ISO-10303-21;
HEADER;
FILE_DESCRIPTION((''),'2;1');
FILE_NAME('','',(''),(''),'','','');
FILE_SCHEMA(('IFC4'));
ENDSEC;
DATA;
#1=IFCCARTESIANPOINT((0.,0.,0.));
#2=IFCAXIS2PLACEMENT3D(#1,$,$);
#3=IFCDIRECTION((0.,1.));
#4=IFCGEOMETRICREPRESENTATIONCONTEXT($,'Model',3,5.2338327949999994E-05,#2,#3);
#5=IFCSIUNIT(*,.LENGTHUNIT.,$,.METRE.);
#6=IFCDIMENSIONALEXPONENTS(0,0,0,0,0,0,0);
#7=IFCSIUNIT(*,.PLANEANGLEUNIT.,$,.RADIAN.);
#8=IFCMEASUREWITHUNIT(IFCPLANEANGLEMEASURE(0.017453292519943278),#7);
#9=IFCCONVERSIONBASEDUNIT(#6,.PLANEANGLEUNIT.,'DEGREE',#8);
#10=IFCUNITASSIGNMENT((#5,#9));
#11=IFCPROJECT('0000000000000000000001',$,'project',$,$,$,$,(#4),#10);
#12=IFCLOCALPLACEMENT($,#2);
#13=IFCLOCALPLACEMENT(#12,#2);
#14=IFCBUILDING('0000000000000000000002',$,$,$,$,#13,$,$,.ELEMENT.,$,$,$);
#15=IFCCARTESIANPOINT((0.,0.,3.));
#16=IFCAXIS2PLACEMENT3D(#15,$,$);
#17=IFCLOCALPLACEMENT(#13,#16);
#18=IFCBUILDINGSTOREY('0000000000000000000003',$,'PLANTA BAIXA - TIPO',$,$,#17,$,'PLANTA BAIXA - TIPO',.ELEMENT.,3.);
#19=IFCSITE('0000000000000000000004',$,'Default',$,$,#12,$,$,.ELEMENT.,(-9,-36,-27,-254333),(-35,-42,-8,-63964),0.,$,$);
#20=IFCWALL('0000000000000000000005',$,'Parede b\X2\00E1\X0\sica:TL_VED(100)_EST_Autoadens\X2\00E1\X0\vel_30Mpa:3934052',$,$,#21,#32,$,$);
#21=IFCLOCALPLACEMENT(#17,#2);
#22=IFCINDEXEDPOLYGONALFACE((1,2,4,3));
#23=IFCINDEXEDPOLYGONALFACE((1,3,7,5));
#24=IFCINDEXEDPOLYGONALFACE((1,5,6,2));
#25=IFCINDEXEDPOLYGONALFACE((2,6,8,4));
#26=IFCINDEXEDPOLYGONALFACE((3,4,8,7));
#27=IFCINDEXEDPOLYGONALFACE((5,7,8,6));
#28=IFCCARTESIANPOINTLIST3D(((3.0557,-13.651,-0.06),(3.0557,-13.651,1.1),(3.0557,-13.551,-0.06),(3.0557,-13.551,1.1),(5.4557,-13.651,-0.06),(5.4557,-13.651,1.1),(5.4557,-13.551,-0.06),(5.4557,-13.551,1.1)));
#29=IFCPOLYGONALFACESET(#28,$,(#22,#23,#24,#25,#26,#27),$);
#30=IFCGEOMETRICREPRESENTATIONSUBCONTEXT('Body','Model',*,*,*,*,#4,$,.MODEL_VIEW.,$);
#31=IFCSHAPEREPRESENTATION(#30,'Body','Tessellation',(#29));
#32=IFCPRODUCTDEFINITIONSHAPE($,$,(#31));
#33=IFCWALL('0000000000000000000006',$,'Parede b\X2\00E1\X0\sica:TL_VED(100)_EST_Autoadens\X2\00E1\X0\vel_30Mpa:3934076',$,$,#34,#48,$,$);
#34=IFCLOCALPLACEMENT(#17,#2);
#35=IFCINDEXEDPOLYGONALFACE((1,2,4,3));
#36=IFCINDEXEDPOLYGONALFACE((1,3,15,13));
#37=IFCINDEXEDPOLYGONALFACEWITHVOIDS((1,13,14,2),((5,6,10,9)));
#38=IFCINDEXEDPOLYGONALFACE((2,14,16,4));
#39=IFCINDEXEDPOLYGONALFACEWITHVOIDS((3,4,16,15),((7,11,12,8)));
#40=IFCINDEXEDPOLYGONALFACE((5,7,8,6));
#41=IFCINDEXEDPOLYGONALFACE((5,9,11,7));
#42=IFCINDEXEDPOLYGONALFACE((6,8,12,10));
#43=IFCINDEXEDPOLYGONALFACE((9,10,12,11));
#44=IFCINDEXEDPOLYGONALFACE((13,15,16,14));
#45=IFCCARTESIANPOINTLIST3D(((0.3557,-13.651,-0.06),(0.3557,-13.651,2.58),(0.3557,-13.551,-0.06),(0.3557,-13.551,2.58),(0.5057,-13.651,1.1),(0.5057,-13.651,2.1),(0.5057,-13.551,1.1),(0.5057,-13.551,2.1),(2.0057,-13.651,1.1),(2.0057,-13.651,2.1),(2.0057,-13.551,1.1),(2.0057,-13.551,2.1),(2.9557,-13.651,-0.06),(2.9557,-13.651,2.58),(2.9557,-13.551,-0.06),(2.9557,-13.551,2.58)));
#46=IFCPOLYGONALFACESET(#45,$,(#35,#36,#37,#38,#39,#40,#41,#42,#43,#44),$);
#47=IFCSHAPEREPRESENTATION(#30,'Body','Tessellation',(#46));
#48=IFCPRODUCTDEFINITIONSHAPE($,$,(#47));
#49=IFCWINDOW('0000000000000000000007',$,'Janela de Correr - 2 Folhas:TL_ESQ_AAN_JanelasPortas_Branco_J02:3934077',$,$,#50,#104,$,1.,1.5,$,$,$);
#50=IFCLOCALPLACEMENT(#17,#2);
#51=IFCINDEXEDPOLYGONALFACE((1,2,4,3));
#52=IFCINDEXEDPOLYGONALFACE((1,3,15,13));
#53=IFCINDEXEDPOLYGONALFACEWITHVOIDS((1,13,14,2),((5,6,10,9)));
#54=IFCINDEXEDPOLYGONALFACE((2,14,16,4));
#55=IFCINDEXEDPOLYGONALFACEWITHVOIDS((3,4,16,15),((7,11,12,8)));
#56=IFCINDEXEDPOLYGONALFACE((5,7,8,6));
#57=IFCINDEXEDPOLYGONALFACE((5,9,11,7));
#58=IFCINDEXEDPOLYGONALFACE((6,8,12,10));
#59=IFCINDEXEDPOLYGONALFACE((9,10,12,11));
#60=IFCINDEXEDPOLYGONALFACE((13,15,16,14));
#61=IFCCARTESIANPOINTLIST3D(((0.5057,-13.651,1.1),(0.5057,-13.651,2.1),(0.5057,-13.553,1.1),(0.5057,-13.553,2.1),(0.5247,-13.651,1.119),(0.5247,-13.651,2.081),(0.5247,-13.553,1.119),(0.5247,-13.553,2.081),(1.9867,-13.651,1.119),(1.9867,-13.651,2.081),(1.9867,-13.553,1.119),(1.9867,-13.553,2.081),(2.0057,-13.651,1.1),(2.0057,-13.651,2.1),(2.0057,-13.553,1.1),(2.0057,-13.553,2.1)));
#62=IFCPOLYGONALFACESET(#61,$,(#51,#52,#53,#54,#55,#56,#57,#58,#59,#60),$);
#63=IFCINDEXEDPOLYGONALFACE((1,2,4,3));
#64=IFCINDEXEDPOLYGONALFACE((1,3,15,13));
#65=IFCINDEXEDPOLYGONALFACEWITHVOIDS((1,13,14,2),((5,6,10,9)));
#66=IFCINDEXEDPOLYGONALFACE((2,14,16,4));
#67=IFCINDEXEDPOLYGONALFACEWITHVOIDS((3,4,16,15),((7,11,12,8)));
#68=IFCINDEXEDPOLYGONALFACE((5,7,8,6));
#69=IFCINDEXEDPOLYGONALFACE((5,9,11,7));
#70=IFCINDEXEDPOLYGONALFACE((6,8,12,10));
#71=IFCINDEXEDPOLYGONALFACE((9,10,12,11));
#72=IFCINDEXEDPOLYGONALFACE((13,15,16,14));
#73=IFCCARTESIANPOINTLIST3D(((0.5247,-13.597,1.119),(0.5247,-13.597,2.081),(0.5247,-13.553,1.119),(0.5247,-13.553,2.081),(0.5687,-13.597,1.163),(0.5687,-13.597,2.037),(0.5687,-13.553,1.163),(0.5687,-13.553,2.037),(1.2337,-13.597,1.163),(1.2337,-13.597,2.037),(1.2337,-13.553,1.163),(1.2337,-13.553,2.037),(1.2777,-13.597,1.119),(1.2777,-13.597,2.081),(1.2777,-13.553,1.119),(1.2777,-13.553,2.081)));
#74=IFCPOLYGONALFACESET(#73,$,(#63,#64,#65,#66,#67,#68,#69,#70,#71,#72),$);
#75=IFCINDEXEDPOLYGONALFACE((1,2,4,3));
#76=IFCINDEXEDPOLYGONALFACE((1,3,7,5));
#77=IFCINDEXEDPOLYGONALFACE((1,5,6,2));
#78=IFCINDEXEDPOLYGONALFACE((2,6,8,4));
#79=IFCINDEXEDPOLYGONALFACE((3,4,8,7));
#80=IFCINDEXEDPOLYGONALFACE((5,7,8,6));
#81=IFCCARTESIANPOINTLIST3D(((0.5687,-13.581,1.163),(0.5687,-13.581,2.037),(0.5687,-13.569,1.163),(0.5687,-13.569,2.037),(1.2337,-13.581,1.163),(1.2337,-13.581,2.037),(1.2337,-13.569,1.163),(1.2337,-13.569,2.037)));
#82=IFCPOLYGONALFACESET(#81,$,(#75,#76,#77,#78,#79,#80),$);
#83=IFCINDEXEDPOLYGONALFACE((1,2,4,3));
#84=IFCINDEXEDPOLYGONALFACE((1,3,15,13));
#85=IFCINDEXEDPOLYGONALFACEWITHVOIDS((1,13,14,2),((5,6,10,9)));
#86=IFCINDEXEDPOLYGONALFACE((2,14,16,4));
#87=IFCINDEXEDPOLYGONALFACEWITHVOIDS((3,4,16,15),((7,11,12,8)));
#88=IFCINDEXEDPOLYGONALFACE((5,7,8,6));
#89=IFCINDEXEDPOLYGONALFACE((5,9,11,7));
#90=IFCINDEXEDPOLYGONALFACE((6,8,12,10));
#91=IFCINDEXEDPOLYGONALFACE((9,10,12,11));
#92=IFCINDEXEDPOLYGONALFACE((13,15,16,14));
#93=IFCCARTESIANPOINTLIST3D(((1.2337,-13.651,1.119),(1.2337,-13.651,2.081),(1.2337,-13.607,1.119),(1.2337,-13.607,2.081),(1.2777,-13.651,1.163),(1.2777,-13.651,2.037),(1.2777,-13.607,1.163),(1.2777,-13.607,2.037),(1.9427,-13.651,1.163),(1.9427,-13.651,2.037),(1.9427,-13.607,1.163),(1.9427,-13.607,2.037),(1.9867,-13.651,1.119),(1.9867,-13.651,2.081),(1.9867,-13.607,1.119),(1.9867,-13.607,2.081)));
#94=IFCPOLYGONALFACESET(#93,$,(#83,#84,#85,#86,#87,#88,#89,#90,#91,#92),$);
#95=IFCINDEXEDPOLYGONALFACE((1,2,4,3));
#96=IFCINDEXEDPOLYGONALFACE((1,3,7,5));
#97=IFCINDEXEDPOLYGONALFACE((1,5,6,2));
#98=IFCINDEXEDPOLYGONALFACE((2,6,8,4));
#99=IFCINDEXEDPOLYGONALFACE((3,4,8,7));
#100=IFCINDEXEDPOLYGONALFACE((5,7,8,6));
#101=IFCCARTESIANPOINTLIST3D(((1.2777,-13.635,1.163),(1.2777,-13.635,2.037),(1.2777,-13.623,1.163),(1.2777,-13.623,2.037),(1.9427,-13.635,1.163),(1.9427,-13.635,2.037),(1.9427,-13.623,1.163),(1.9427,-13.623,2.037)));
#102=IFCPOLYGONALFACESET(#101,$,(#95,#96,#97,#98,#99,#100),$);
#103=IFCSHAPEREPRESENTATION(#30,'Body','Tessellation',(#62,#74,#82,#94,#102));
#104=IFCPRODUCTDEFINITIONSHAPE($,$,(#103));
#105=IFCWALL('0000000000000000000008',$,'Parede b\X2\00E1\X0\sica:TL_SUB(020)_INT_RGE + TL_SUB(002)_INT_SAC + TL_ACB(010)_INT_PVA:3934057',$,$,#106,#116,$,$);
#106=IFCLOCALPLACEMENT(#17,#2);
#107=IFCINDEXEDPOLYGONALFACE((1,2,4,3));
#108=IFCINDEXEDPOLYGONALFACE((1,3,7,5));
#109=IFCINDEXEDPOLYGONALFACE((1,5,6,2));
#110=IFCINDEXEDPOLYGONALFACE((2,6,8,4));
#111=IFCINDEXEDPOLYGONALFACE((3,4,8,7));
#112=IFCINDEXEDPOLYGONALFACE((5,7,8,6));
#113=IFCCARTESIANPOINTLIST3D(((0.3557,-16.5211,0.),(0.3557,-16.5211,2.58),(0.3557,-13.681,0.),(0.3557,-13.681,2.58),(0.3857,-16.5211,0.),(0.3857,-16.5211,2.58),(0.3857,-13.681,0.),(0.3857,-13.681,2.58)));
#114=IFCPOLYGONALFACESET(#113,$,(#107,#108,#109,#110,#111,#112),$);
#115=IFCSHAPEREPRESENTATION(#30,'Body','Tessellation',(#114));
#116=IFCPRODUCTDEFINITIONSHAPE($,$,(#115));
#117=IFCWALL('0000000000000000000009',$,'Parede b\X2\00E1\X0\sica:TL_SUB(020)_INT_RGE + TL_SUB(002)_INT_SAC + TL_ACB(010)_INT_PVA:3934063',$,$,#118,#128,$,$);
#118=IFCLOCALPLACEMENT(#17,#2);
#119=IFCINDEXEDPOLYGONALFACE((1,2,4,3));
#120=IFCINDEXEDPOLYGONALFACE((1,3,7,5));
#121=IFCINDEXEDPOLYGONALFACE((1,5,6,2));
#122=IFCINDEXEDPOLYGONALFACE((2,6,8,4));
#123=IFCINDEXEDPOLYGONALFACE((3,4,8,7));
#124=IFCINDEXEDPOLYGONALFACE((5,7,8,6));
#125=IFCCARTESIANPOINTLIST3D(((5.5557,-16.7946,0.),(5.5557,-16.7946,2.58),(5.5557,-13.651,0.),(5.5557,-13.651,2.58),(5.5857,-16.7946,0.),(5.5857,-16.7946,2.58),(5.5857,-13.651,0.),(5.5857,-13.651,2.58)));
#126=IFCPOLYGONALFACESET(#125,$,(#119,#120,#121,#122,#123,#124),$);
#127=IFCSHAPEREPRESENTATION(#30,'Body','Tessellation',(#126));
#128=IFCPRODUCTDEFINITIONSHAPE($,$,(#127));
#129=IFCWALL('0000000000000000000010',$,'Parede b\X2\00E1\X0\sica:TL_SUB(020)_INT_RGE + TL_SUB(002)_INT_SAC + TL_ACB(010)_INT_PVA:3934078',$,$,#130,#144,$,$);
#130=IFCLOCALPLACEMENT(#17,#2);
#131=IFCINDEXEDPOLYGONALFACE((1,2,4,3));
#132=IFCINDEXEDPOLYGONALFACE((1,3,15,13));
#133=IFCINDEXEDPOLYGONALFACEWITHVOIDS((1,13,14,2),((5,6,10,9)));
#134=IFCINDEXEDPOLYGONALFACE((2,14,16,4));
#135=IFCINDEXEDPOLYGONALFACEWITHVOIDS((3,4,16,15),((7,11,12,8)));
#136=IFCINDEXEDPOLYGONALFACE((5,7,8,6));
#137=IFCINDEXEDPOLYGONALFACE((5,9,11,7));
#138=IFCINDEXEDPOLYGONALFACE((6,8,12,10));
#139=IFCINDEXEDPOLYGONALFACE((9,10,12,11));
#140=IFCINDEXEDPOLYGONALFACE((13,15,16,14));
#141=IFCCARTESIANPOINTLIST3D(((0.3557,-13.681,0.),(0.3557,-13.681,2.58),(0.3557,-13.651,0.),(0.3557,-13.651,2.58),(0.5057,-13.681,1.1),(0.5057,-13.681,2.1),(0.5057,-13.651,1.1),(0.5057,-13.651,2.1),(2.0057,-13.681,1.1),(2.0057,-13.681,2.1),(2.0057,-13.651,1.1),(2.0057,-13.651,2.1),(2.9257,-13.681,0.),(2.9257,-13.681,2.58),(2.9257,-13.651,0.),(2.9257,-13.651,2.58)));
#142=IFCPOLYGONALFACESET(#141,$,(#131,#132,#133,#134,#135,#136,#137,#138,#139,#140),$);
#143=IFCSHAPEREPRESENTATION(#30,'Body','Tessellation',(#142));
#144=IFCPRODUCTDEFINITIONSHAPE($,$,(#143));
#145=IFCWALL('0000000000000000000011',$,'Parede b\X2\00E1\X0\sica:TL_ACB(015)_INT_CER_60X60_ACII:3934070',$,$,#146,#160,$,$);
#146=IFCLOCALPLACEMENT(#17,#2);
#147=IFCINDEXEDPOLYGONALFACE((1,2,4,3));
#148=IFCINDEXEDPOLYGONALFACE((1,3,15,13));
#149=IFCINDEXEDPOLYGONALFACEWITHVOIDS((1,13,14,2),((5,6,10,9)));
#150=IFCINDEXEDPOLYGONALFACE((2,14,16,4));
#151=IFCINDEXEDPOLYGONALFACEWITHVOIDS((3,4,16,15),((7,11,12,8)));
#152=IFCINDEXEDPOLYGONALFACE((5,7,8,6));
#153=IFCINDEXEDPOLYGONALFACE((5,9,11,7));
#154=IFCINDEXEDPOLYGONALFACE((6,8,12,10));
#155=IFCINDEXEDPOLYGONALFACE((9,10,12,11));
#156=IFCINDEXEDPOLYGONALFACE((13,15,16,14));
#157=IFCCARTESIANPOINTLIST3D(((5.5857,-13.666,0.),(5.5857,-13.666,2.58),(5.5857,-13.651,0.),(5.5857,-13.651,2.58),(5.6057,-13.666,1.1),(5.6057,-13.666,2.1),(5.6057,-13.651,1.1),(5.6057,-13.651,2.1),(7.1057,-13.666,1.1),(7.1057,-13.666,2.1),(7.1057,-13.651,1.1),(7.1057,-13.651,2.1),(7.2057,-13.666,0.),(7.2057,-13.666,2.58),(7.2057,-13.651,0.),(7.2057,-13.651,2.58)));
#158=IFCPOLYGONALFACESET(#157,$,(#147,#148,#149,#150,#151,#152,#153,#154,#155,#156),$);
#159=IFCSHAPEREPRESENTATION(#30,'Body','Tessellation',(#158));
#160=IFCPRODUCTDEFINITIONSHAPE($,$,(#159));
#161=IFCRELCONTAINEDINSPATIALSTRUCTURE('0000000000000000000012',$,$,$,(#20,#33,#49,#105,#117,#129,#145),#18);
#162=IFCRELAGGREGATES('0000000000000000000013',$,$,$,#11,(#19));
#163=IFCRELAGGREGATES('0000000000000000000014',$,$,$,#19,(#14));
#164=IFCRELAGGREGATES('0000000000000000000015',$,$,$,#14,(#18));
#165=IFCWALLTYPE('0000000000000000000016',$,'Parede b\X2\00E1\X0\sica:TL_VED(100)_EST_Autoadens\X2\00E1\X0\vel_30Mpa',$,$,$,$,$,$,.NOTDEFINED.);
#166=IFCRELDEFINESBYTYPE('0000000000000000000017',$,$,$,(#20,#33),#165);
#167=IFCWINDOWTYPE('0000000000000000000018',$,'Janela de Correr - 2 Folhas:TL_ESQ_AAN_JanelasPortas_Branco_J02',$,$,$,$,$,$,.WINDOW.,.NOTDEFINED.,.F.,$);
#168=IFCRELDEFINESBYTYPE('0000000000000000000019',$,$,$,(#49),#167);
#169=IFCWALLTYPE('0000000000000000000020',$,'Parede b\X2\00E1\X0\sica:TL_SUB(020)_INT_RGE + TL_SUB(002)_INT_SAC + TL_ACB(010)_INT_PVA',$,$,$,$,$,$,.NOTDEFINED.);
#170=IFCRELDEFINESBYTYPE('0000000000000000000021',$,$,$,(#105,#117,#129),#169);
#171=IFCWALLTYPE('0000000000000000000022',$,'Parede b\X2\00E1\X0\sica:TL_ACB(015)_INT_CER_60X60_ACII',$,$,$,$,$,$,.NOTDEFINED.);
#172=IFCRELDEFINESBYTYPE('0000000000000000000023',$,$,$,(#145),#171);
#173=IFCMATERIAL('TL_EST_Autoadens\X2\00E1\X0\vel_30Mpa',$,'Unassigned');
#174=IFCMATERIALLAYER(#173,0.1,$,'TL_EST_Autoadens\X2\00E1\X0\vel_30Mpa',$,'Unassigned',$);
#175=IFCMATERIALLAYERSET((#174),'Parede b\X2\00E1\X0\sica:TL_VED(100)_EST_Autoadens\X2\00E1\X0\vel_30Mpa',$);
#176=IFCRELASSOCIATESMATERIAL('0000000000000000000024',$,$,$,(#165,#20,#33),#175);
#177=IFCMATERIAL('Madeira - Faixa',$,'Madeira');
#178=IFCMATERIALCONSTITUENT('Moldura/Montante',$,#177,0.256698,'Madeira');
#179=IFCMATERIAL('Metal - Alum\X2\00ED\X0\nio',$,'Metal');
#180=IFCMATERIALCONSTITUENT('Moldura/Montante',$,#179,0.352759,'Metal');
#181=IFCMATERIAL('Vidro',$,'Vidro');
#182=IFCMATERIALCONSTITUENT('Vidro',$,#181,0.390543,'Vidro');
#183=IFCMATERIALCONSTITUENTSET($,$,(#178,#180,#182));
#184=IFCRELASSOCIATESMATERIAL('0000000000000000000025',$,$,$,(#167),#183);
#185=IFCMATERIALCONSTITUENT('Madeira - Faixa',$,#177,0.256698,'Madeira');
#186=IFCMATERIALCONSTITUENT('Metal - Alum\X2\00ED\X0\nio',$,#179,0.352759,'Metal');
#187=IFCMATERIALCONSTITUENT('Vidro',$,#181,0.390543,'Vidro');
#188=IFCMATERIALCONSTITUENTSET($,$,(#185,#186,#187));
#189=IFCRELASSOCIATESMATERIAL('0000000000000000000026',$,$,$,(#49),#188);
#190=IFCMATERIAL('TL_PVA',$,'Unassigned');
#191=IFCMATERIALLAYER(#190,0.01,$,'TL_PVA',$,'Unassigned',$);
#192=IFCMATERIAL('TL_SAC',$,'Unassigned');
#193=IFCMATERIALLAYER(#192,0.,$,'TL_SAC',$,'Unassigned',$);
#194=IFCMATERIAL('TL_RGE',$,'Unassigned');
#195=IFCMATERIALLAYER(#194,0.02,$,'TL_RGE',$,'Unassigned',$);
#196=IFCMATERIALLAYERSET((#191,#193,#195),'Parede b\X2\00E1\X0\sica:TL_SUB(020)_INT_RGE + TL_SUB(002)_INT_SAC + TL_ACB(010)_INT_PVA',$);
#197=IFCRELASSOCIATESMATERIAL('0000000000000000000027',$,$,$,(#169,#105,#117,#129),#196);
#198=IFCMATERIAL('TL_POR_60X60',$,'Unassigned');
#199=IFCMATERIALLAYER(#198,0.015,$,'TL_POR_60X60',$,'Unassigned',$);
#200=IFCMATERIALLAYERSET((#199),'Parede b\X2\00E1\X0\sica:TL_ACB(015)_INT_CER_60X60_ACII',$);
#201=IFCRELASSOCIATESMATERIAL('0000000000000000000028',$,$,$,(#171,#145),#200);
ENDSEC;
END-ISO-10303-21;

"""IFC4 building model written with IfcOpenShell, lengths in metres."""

from ifc_helpers import new_model, entity, si_unit, converted_unit, direction, frame, frame_2d, origin, origin_2d_with_axis, place, context, subcontext, project, spatial, polyline, rectangle, outline, extrude, source, transform, mapped, material, layer, layer_set, layer_usage, constituent, constituent_set, type_object, type_shapes, element, fill, save


model = new_model("IFC4")

# Units and contexts
model_context = context("Model", 3, precision=5.2338327949999994e-05, world=origin(), true_north=direction((0.0, 1.0)))
body_context = subcontext(model_context, "Body", "Model", "MODEL_VIEW")
ifc_project = project(units=[si_unit("LENGTHUNIT", "METRE"), converted_unit("PLANEANGLEUNIT", "DEGREE", entity("IfcPlaneAngleMeasure", 0.017453292519943278), si_unit("PLANEANGLEUNIT", "RADIAN"), dimensions=[0, 0, 0, 0, 0, 0, 0])], contexts=[model_context])

# Site, building, storey
site_placement = place(None, frame((0.0, 0.0, 0.0)))
site = spatial("IfcSite", under=ifc_project, at=site_placement, Name="Default", CompositionType="ELEMENT", RefLatitude=(-9, -36, -27, -254333), RefLongitude=(-35, -42, -8, -63964), RefElevation=0.0)
building_placement = place(site_placement, origin())
building = spatial("IfcBuilding", under=site, at=building_placement, CompositionType="ELEMENT")
storey_placement = place(building_placement, frame((0.0, 0.0, 3.0)))
storey = spatial("IfcBuildingStorey", under=building, at=storey_placement, Name="PLANTA BAIXA - TIPO", LongName="PLANTA BAIXA - TIPO", CompositionType="ELEMENT", Elevation=3.0)

# Wall
ifc_material_1 = material(Name="TL_EST_Autoadensável_30Mpa", Category="Unassigned")
ifc_layer_1 = layer(ifc_material_1, 0.1, Name="TL_EST_Autoadensável_30Mpa", Category="Unassigned")
ifc_layer_set_1 = layer_set([ifc_layer_1], Name="Parede básica:TL_VED(100)_EST_Autoadensável_30Mpa")
ifc_layer_usage_1 = layer_usage(ifc_layer_set_1, "AXIS2", "NEGATIVE", 0.05)
wall_type_1 = type_object("IfcWallType", Name="Parede básica:TL_VED(100)_EST_Autoadensável_30Mpa", PredefinedType="NOTDEFINED", material=ifc_layer_set_1)
wall_1_placement = place(storey_placement, frame((3.0557, -13.601, -0.06)))
element("IfcWall", 1, at=wall_1_placement, inside=storey, type_object=wall_type_1, material=ifc_layer_usage_1, Name="Parede básica:TL_VED(100)_EST_Autoadensável_30Mpa:3934052", context=body_context, shape_type="SweptSolid", body=[
    extrude(rectangle(XDim=2.4, YDim=0.1, at=frame_2d((1.2, 0.0), x_axis=(-1.0, 0.0))), origin(), (0.0, 0.0, 1.0), 1.16),
])

# Wall, opening, window
ifc_layer_usage_2 = layer_usage(ifc_layer_set_1, "AXIS2", "NEGATIVE", 0.05)
wall_2_placement = place(storey_placement, frame((0.3557, -13.601, -0.06)))
wall_2 = element("IfcWall", 2, at=wall_2_placement, inside=storey, type_object=wall_type_1, material=ifc_layer_usage_2, Name="Parede básica:TL_VED(100)_EST_Autoadensável_30Mpa:3934076", context=body_context, shape_type="SweptSolid", body=[
    extrude(rectangle(XDim=2.6, YDim=0.1, at=frame_2d((1.3, 0.0), x_axis=(-1.0, 0.0))), origin(), (0.0, 0.0, 1.0), 2.64),
])
opening_1_placement = place(wall_2_placement, frame((0.15, -0.05, 1.16)))
opening_1 = element("IfcOpeningElement", 3, at=opening_1_placement, cuts=wall_2, PredefinedType="OPENING", context=body_context, shape_type="SweptSolid", body=[
    extrude(rectangle(XDim=1.0, YDim=1.5, at=frame_2d((0.5, 0.75), x_axis=(-1.0, 0.0))), frame((0.0, 0.0, 0.0), z_axis=(0.0, 1.0, 0.0), x_axis=(0.0, 0.0, 1.0)), (0.0, 0.0, 1.0), 0.1),
])
ifc_material_2 = material(Name="Madeira - Faixa", Category="Madeira")
ifc_constituent_1 = constituent(ifc_material_2, Name="Madeira - Faixa", Category="Madeira", fraction=0.256698)
ifc_material_3 = material(Name="Metal - Alumínio", Category="Metal")
ifc_constituent_2 = constituent(ifc_material_3, Name="Metal - Alumínio", Category="Metal", fraction=0.352759)
ifc_material_4 = material(Name="Vidro", Category="Vidro")
ifc_constituent_3 = constituent(ifc_material_4, Name="Vidro", Category="Vidro", fraction=0.390543)
ifc_constituent_set_1 = constituent_set(constituents=[ifc_constituent_1, ifc_constituent_2, ifc_constituent_3])
ifc_constituent_4 = constituent(ifc_material_2, Name="Moldura/Montante", Category="Madeira", fraction=0.256698)
ifc_constituent_5 = constituent(ifc_material_3, Name="Moldura/Montante", Category="Metal", fraction=0.352759)
ifc_constituent_6 = constituent(ifc_material_4, Name="Vidro", Category="Vidro", fraction=0.390543)
ifc_constituent_set_2 = constituent_set(constituents=[ifc_constituent_4, ifc_constituent_5, ifc_constituent_6])
window_type = type_object("IfcWindowType", Name="Janela de Correr - 2 Folhas:TL_ESQ_AAN_JanelasPortas_Branco_J02", ParameterTakesPrecedence=False, PartitioningType="NOTDEFINED", PredefinedType="WINDOW", material=ifc_constituent_set_2)
shared_shape_1 = source(origin(), body_context, "Body", "SweptSolid", [
    extrude(outline(polyline([(-0.75, -0.5), (0.75, -0.5), (0.75, 0.5), (-0.75, 0.5), (-0.75, -0.5)]), holes=[polyline([(-0.731, -0.481), (-0.731, 0.481), (0.731, 0.481), (0.731, -0.481), (-0.731, -0.481)])]), frame((0.75, 0.124, 0.5), z_axis=(0.0, -1.0, 0.0), x_axis=(-1.0, 0.0, 0.0)), (0.0, 0.0, 1.0), 0.098),
    extrude(outline(polyline([(-0.3765, -0.481), (0.3765, -0.481), (0.3765, 0.481), (-0.3765, 0.481), (-0.3765, -0.481)]), holes=[polyline([(-0.3325, -0.437), (-0.3325, 0.437), (0.3325, 0.437), (0.3325, -0.437), (-0.3325, -0.437)])]), frame((0.3955, 0.124, 0.5), z_axis=(0.0, -1.0, 0.0), x_axis=(-1.0, 0.0, 0.0)), (0.0, 0.0, 1.0), 0.044),
    extrude(rectangle(XDim=0.665, YDim=0.012, at=origin_2d_with_axis()), frame((0.3955, 0.102, 0.063), z_axis=(0.0, 0.0, 1.0), x_axis=(-1.0, 0.0, 0.0)), (0.0, 0.0, 1.0), 0.874),
    extrude(outline(polyline([(-0.481, -0.3765), (0.481, -0.3765), (0.481, 0.3765), (-0.481, 0.3765), (-0.481, -0.3765)]), holes=[polyline([(-0.437, -0.3325), (-0.437, 0.3325), (0.437, 0.3325), (0.437, -0.3325), (-0.437, -0.3325)])]), frame((1.1045, 0.07, 0.5), z_axis=(0.0, -1.0, 0.0), x_axis=(0.0, 0.0, -1.0)), (0.0, 0.0, 1.0), 0.044),
    extrude(rectangle(XDim=0.665, YDim=0.012, at=origin_2d_with_axis()), frame((1.1045, 0.048, 0.063), z_axis=(0.0, 0.0, 1.0), x_axis=(-1.0, 0.0, 0.0)), (0.0, 0.0, 1.0), 0.874),
])
type_shapes(window_type, [shared_shape_1])
window_placement = place(opening_1_placement, frame((0.0, -0.026, 0.0)))
window = element("IfcWindow", 4, at=window_placement, inside=storey, type_object=window_type, material=ifc_constituent_set_1, Name="Janela de Correr - 2 Folhas:TL_ESQ_AAN_JanelasPortas_Branco_J02:3934077", OverallHeight=1.0, OverallWidth=1.5, context=body_context, shape_type="MappedRepresentation", body=[
    mapped(shared_shape_1, transform((0.0, 0.0, 0.0), scale=1.0)),
])
fill(opening_1, window)

# Walls
ifc_material_5 = material(Name="TL_PVA", Category="Unassigned")
ifc_layer_2 = layer(ifc_material_5, 0.01, Name="TL_PVA", Category="Unassigned")
ifc_material_6 = material(Name="TL_SAC", Category="Unassigned")
ifc_layer_3 = layer(ifc_material_6, 0.0, Name="TL_SAC", Category="Unassigned")
ifc_material_7 = material(Name="TL_RGE", Category="Unassigned")
ifc_layer_4 = layer(ifc_material_7, 0.02, Name="TL_RGE", Category="Unassigned")
ifc_layer_set_2 = layer_set([ifc_layer_2, ifc_layer_3, ifc_layer_4], Name="Parede básica:TL_SUB(020)_INT_RGE + TL_SUB(002)_INT_SAC + TL_ACB(010)_INT_PVA")
ifc_layer_usage_3 = layer_usage(ifc_layer_set_2, "AXIS2", "NEGATIVE", 0.015)
wall_type_2 = type_object("IfcWallType", Name="Parede básica:TL_SUB(020)_INT_RGE + TL_SUB(002)_INT_SAC + TL_ACB(010)_INT_PVA", PredefinedType="NOTDEFINED", material=ifc_layer_set_2)
wall_3_placement = place(storey_placement, frame((0.3707, -13.681, 0.0), z_axis=(0.0, 0.0, 1.0), x_axis=(0.0, -1.0, 0.0)))
element("IfcWall", 5, at=wall_3_placement, inside=storey, type_object=wall_type_2, material=ifc_layer_usage_3, Name="Parede básica:TL_SUB(020)_INT_RGE + TL_SUB(002)_INT_SAC + TL_ACB(010)_INT_PVA:3934057", context=body_context, shape_type="SweptSolid", body=[
    extrude(rectangle(XDim=2.8401, YDim=0.03, at=frame_2d((1.4201, 0.0), x_axis=(-1.0, 0.0))), origin(), (0.0, 0.0, 1.0), 2.58),
])
ifc_layer_usage_4 = layer_usage(ifc_layer_set_2, "AXIS2", "NEGATIVE", 0.015)
wall_4_placement = place(storey_placement, frame((5.5707, -13.651, 0.0), z_axis=(0.0, 0.0, 1.0), x_axis=(0.0, -1.0, 0.0)))
element("IfcWall", 6, at=wall_4_placement, inside=storey, type_object=wall_type_2, material=ifc_layer_usage_4, Name="Parede básica:TL_SUB(020)_INT_RGE + TL_SUB(002)_INT_SAC + TL_ACB(010)_INT_PVA:3934063", context=body_context, shape_type="SweptSolid", body=[
    extrude(rectangle(XDim=3.1437, YDim=0.03, at=frame_2d((1.5718, 0.0), x_axis=(-1.0, 0.0))), origin(), (0.0, 0.0, 1.0), 2.58),
])

# Walls, openings
ifc_layer_usage_5 = layer_usage(ifc_layer_set_2, "AXIS2", "NEGATIVE", 0.015)
wall_5_placement = place(storey_placement, frame((2.9257, -13.666, 0.0), z_axis=(0.0, 0.0, 1.0), x_axis=(-1.0, 0.0, 0.0)))
wall_5 = element("IfcWall", 7, at=wall_5_placement, inside=storey, type_object=wall_type_2, material=ifc_layer_usage_5, Name="Parede básica:TL_SUB(020)_INT_RGE + TL_SUB(002)_INT_SAC + TL_ACB(010)_INT_PVA:3934078", context=body_context, shape_type="SweptSolid", body=[
    extrude(rectangle(XDim=2.57, YDim=0.03, at=frame_2d((1.285, 0.0), x_axis=(-1.0, 0.0))), origin(), (0.0, 0.0, 1.0), 2.58),
])
opening_2_placement = place(wall_5_placement, frame((2.9257, -13.666, 1.1)))
element("IfcOpeningElement", 8, at=opening_2_placement, cuts=wall_5, PredefinedType="OPENING", context=body_context, shape_type="SweptSolid", body=[
    extrude(rectangle(XDim=1.0, YDim=1.5, at=frame_2d((0.0, 0.0), x_axis=(0.0, 1.0))), frame((-1.2557, 12.127, 0.5), z_axis=(0.0, 1.0, 0.0), x_axis=(1.0, 0.0, 0.0)), (0.0, 0.0, 1.0), 3.048),
])
ifc_material_8 = material(Name="TL_POR_60X60", Category="Unassigned")
ifc_layer_5 = layer(ifc_material_8, 0.015, Name="TL_POR_60X60", Category="Unassigned")
ifc_layer_set_3 = layer_set([ifc_layer_5], Name="Parede básica:TL_ACB(015)_INT_CER_60X60_ACII")
ifc_layer_usage_6 = layer_usage(ifc_layer_set_3, "AXIS2", "NEGATIVE", 0.0075)
wall_type_3 = type_object("IfcWallType", Name="Parede básica:TL_ACB(015)_INT_CER_60X60_ACII", PredefinedType="NOTDEFINED", material=ifc_layer_set_3)
wall_6_placement = place(storey_placement, frame((7.2057, -13.6585, 0.0), z_axis=(0.0, 0.0, 1.0), x_axis=(-1.0, 0.0, 0.0)))
wall_6 = element("IfcWall", 9, at=wall_6_placement, inside=storey, type_object=wall_type_3, material=ifc_layer_usage_6, Name="Parede básica:TL_ACB(015)_INT_CER_60X60_ACII:3934070", context=body_context, shape_type="SweptSolid", body=[
    extrude(rectangle(XDim=1.62, YDim=0.015, at=frame_2d((0.81, 0.0), x_axis=(-1.0, 0.0))), origin(), (0.0, 0.0, 1.0), 2.58),
])
opening_3_placement = place(wall_6_placement, frame((7.2057, -13.6585, 1.1)))
element("IfcOpeningElement", 10, at=opening_3_placement, cuts=wall_6, PredefinedType="OPENING", context=body_context, shape_type="SweptSolid", body=[
    extrude(rectangle(XDim=1.0, YDim=1.5, at=frame_2d((0.0, 0.0), x_axis=(0.0, 1.0))), frame((-6.3557, 12.127, 0.5), z_axis=(0.0, 1.0, 0.0), x_axis=(1.0, 0.0, 0.0)), (0.0, 0.0, 1.0), 3.048),
])

save(model, "model.ifc")
